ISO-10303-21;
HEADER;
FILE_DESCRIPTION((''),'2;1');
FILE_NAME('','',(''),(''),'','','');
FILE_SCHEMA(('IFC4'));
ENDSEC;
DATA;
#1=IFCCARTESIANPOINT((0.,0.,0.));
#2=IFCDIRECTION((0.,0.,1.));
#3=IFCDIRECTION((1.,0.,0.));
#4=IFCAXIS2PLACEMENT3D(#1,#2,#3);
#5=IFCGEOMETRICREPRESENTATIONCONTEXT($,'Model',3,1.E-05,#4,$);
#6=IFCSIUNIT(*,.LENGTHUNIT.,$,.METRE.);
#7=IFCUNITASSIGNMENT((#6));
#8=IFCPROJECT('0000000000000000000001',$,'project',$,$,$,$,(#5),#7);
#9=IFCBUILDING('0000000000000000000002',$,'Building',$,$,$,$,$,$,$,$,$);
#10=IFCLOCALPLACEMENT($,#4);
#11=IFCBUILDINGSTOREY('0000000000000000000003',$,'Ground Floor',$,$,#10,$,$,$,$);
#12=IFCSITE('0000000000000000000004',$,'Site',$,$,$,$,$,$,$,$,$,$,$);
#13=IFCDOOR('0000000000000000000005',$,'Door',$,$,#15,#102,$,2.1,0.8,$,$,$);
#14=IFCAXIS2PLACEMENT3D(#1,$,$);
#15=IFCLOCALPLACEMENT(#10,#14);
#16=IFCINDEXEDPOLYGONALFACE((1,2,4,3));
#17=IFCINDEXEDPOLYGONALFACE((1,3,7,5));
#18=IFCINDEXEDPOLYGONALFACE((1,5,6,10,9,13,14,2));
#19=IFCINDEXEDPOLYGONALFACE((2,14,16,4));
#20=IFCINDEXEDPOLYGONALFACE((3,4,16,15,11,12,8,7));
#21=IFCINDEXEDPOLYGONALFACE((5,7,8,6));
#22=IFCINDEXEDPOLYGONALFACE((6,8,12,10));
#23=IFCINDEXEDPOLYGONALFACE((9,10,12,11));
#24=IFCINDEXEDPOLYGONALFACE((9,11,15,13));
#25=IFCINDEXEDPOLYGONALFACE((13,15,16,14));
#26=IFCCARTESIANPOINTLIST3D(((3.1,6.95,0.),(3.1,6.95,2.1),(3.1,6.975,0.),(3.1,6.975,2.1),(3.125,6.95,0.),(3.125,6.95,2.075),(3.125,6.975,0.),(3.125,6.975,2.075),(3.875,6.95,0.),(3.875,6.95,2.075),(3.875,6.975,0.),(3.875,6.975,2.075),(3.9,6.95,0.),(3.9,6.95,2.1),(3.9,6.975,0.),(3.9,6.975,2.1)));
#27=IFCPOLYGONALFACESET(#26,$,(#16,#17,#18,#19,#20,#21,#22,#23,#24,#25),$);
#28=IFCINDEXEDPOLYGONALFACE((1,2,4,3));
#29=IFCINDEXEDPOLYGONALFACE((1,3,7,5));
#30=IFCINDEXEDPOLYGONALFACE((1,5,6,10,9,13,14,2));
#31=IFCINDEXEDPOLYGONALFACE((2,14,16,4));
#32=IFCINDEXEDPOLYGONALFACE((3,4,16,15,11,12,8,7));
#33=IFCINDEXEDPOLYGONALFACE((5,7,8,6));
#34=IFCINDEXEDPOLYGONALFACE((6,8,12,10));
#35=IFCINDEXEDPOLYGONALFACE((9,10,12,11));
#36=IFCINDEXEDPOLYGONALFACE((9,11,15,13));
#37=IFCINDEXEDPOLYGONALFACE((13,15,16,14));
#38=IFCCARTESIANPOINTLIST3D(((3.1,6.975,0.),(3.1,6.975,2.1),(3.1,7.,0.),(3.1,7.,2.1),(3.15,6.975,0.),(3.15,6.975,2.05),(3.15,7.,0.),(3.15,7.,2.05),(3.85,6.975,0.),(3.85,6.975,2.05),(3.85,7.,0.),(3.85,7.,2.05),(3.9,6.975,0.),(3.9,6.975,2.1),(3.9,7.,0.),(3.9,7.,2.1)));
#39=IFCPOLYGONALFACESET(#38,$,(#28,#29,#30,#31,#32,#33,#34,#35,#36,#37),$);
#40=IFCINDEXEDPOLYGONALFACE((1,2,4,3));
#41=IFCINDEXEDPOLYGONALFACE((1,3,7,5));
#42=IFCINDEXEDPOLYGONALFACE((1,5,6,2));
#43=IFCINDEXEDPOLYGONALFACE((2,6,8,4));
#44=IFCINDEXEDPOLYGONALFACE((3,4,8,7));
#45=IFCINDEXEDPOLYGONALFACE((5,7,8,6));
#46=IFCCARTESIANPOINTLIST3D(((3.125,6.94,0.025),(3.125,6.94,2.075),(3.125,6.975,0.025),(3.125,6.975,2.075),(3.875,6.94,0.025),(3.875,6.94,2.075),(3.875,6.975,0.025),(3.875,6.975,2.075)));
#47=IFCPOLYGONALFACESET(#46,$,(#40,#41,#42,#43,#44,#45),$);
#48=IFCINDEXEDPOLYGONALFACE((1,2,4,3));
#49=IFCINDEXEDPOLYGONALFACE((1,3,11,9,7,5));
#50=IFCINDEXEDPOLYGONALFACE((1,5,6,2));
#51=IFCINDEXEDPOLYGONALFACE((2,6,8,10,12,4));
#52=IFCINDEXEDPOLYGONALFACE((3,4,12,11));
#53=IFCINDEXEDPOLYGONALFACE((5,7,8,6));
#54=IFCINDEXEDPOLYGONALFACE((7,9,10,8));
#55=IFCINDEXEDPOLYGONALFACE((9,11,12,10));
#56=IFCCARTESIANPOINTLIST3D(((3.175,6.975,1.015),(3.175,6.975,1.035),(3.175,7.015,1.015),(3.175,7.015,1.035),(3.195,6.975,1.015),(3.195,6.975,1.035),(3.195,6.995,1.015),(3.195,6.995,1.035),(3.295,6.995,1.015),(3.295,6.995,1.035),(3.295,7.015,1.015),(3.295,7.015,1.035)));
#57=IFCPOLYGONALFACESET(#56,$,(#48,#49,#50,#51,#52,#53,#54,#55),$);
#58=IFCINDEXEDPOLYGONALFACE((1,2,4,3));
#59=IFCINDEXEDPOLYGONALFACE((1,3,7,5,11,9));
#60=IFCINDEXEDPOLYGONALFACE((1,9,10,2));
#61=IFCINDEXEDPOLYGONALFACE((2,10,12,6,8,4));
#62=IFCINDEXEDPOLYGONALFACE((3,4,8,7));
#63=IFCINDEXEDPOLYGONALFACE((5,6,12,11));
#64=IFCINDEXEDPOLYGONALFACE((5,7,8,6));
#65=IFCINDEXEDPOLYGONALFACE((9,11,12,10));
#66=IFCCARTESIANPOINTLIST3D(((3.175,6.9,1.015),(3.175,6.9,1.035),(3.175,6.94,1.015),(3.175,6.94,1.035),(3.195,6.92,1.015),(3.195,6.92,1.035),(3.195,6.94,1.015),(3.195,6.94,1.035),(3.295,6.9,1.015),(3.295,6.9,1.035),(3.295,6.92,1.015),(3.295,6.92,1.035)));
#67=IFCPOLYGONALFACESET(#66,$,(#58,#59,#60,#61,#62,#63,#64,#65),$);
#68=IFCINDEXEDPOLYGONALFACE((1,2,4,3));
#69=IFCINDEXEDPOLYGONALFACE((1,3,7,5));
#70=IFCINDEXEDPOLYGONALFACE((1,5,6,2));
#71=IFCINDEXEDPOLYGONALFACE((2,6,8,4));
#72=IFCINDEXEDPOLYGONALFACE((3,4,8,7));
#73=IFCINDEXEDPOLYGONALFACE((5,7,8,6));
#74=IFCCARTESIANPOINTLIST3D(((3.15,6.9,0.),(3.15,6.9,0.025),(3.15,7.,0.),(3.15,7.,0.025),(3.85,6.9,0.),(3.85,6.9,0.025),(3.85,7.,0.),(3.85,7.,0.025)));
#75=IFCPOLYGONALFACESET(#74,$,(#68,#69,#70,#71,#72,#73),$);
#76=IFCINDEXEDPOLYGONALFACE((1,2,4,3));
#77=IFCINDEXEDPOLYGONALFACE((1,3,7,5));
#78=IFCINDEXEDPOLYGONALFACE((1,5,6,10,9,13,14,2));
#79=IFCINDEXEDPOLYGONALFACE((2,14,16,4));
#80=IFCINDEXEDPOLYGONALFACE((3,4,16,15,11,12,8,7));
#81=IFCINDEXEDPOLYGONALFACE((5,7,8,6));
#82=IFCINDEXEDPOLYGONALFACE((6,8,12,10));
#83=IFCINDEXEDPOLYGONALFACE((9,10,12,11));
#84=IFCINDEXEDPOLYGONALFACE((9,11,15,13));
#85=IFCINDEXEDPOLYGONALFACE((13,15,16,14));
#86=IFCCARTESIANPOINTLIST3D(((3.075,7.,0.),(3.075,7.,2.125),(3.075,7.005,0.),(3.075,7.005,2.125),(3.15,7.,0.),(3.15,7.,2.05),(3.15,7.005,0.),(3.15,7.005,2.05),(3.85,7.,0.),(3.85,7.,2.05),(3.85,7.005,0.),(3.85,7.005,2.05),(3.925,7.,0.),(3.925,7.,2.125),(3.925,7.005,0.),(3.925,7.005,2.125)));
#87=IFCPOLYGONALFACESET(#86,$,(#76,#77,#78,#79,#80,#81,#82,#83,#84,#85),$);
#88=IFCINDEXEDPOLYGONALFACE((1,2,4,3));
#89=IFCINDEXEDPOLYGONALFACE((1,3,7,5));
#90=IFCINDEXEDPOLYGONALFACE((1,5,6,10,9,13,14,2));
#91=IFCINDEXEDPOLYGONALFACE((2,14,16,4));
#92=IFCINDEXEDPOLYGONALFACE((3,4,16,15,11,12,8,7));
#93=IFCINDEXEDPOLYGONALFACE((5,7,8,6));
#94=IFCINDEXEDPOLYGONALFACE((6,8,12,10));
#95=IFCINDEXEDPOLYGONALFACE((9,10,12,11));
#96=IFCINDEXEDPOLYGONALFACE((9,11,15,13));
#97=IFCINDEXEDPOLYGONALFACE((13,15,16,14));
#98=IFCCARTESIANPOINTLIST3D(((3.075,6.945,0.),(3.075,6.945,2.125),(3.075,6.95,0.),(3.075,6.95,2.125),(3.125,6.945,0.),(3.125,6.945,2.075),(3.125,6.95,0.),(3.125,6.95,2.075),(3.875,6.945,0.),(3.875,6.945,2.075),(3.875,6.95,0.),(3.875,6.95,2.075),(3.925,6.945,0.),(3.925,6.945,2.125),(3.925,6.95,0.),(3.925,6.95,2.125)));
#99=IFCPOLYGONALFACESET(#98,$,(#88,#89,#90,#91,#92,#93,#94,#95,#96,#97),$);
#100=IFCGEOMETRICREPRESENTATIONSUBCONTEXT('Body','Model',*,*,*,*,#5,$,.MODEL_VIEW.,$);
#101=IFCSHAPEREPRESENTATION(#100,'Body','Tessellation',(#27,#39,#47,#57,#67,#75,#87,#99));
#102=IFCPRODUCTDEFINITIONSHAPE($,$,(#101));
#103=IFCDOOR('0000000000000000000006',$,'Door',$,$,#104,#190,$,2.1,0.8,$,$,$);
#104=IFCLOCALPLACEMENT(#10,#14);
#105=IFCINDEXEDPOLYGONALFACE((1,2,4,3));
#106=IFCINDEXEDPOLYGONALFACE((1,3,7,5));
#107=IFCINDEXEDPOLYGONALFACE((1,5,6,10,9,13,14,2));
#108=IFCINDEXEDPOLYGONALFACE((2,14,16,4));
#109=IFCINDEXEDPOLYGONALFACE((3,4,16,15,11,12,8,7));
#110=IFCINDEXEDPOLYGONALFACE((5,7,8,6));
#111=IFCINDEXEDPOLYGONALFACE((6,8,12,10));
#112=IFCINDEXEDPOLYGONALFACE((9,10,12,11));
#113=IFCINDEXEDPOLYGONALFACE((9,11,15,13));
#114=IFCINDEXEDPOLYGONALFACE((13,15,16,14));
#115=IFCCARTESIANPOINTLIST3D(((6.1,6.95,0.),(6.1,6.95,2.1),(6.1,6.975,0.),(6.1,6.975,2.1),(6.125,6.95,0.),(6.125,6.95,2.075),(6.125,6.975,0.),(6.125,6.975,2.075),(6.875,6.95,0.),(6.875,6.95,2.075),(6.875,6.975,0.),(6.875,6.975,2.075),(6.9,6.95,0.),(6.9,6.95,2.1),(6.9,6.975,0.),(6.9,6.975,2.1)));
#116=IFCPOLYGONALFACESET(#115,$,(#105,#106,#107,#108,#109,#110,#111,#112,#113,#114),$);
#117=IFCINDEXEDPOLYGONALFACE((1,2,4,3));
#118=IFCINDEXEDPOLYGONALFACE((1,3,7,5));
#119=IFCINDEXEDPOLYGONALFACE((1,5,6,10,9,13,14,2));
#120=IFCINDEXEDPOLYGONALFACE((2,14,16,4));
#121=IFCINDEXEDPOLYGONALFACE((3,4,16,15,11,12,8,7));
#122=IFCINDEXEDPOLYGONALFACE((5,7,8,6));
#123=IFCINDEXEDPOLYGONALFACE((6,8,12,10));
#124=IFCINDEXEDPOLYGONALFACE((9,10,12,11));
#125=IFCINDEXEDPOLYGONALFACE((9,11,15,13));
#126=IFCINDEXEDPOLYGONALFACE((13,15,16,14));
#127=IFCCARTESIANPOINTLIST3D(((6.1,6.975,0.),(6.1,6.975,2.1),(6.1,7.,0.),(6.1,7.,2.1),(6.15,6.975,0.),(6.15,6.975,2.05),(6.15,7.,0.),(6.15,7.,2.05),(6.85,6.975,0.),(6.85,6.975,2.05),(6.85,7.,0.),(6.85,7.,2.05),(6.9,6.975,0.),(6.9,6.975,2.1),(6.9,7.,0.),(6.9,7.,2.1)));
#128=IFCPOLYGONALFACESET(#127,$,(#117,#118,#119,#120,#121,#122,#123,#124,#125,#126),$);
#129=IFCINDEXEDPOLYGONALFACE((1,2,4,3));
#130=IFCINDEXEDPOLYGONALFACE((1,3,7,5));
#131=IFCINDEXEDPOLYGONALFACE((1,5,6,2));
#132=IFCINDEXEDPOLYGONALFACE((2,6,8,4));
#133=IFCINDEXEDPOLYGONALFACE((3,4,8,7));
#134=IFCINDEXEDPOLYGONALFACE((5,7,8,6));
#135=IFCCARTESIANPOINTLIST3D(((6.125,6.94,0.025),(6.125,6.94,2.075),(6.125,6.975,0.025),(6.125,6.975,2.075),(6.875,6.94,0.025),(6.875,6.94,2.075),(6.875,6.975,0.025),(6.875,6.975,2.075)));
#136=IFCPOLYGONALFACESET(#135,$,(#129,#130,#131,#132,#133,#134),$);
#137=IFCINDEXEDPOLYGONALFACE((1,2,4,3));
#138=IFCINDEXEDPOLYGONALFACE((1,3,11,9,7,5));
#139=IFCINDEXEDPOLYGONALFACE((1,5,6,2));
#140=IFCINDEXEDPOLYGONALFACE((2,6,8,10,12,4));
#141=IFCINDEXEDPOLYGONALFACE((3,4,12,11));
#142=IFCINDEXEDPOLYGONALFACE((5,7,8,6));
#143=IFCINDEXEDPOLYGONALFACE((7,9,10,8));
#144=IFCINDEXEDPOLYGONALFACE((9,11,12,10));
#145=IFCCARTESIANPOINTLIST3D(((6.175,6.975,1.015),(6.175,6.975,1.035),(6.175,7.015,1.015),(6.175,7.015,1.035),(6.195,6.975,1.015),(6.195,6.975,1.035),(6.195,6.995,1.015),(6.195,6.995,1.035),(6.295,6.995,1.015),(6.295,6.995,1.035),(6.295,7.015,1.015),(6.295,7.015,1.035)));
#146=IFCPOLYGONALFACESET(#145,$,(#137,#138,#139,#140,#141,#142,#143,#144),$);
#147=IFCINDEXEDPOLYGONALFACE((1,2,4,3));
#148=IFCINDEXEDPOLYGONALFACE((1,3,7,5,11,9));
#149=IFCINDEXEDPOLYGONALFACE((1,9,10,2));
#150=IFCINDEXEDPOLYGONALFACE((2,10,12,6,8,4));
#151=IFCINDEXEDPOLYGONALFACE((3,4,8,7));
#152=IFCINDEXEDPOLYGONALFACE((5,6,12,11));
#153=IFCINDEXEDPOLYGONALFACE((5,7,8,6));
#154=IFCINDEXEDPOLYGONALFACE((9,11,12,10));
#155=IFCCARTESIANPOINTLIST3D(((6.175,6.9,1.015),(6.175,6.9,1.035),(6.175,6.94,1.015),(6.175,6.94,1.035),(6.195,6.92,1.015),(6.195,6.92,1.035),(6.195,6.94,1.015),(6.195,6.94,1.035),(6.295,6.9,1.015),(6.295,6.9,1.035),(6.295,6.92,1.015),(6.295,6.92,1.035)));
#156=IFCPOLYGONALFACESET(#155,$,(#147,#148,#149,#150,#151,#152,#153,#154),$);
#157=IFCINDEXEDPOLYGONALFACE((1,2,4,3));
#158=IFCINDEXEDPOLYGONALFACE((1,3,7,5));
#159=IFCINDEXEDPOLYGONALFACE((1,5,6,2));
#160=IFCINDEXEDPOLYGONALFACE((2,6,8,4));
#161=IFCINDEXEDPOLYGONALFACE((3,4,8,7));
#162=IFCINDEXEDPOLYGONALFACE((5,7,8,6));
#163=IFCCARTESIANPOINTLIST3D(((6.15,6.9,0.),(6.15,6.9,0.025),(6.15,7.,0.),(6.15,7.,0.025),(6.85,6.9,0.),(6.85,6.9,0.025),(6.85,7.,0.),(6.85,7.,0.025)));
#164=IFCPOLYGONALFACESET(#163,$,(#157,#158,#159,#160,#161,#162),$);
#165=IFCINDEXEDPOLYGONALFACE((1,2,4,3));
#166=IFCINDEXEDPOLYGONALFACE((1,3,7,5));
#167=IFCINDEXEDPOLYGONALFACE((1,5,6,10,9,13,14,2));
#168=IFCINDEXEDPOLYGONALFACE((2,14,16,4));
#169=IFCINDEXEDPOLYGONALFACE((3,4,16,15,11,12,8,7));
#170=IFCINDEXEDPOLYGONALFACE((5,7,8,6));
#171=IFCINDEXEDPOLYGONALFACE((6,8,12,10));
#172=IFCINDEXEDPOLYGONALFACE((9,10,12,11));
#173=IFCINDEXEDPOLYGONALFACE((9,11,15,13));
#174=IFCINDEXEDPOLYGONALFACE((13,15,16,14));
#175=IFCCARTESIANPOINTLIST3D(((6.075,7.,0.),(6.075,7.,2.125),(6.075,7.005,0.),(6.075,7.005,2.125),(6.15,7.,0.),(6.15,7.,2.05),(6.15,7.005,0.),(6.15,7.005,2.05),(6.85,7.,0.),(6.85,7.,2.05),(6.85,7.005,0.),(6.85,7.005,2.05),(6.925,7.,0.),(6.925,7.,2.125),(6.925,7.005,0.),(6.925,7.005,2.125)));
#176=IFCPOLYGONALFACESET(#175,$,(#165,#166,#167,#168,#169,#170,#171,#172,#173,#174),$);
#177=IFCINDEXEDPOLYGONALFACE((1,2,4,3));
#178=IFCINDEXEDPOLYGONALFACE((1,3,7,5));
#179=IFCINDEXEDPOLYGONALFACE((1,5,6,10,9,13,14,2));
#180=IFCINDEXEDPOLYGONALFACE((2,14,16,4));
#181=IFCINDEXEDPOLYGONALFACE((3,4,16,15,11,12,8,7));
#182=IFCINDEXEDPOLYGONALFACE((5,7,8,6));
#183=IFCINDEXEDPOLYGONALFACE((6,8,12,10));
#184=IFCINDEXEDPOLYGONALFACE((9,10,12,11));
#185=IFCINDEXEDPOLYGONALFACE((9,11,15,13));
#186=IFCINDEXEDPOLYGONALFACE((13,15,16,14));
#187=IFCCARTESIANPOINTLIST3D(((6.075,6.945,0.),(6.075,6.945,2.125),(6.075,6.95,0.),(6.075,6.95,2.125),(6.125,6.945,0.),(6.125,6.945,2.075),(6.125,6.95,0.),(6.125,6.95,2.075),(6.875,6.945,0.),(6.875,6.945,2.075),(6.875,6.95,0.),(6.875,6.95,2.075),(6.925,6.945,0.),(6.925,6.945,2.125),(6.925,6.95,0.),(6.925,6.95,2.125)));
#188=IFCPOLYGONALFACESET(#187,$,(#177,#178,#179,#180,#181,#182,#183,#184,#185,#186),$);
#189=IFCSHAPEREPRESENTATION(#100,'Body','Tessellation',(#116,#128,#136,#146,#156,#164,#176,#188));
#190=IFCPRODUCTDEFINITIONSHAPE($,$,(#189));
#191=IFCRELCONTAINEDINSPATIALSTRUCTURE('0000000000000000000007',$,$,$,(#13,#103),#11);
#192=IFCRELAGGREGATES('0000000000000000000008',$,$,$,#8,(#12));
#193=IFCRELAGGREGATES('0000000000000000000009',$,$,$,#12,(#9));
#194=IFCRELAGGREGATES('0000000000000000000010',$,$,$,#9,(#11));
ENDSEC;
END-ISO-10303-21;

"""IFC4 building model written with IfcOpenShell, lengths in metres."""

from ifc_helpers import new_model, si_unit, frame, origin_with_axes, place, context, subcontext, project, spatial, line, indexed_curve, outline, extrude, element, save


model = new_model("IFC4")

# Units and contexts
model_context = context("Model", 3, precision=1e-05, world=origin_with_axes())
body_context = subcontext(model_context, "Body", "Model", "MODEL_VIEW")
ifc_project = project(units=[si_unit("LENGTHUNIT", "METRE")], contexts=[model_context])

# Site, building, storey
site = spatial("IfcSite", under=ifc_project, Name="Site")
building = spatial("IfcBuilding", under=site, Name="Building")
storey_placement = place(None, origin_with_axes())
storey = spatial("IfcBuildingStorey", under=building, at=storey_placement, Name="Ground Floor")

# Doors
door_1_placement = place(storey_placement, frame((3.9, 7.0, 0.0), z_axis=(0.0, 0.0, 1.0), x_axis=(-1.0, 0.0, 0.0)))
element("IfcDoor", 1, at=door_1_placement, inside=storey, Name="Door", OverallHeight=2.1, OverallWidth=0.8, context=body_context, shape_type="SweptSolid", body=[
    extrude(outline(indexed_curve([(0.0, 0.0), (0.0, 2.1), (0.8, 2.1), (0.8, 0.0), (0.775, 0.0), (0.775, 2.075), (0.025, 2.075), (0.025, 0.0)], segments=[line(1, 2, 3, 4, 5, 6, 7, 8, 1)])), frame((0.0, 0.025, 0.0), z_axis=(0.0, -1.0, 0.0), x_axis=(1.0, 0.0, 0.0)), (0.0, 0.0, -1.0), 0.025),
    extrude(outline(indexed_curve([(0.0, 0.0), (0.0, 2.1), (0.8, 2.1), (0.8, 0.0), (0.75, 0.0), (0.75, 2.05), (0.05, 2.05), (0.05, 0.0)], segments=[line(1, 2, 3, 4, 5, 6, 7, 8, 1)])), frame((0.0, 0.0, 0.0), z_axis=(0.0, -1.0, 0.0), x_axis=(1.0, 0.0, 0.0)), (0.0, 0.0, -1.0), 0.025),
    extrude(outline(indexed_curve([(0.0, 0.0), (0.75, 0.0), (0.75, 0.035), (0.0, 0.035)], segments=[line(1, 2, 3, 4, 1)])), frame((0.025, 0.025, 0.025), z_axis=(0.0, 0.0, 1.0), x_axis=(1.0, 0.0, 0.0)), (0.0, 0.0, 1.0), 2.05),
    extrude(outline(indexed_curve([(0.0, 0.0), (0.0, -0.04), (-0.12, -0.04), (-0.12, -0.02), (-0.02, -0.02), (-0.02, 0.0)], segments=[line(1, 2, 3, 4, 5, 6, 1)])), frame((0.725, 0.025, 1.015), z_axis=(0.0, 0.0, 1.0), x_axis=(1.0, 0.0, 0.0)), (0.0, 0.0, 1.0), 0.02),
    extrude(outline(indexed_curve([(0.0, 0.0), (0.0, 0.04), (-0.12, 0.04), (-0.12, 0.02), (-0.02, 0.02), (-0.02, 0.0)], segments=[line(1, 2, 3, 4, 5, 6, 1)])), frame((0.725, 0.06, 1.015), z_axis=(0.0, 0.0, 1.0), x_axis=(1.0, 0.0, 0.0)), (0.0, 0.0, 1.0), 0.02),
    extrude(outline(indexed_curve([(0.0, 0.0), (0.7, 0.0), (0.7, 0.1), (0.0, 0.1)], segments=[line(1, 2, 3, 4, 1)])), frame((0.05, 0.0, 0.0), z_axis=(0.0, 0.0, 1.0), x_axis=(1.0, 0.0, 0.0)), (0.0, 0.0, 1.0), 0.025),
    extrude(outline(indexed_curve([(0.0, 0.0), (0.0, 2.125), (0.85, 2.125), (0.85, 0.0), (0.775, 0.0), (0.775, 2.05), (0.075, 2.05), (0.075, 0.0)], segments=[line(1, 2, 3, 4, 5, 6, 7, 8, 1)])), frame((-0.025, -0.005, 0.0), z_axis=(0.0, -1.0, 0.0), x_axis=(1.0, 0.0, 0.0)), (0.0, 0.0, -1.0), 0.005),
    extrude(outline(indexed_curve([(0.0, 0.0), (0.0, 2.125), (0.85, 2.125), (0.85, 0.0), (0.8, 0.0), (0.8, 2.075), (0.05, 2.075), (0.05, 0.0)], segments=[line(1, 2, 3, 4, 5, 6, 7, 8, 1)])), frame((-0.025, 0.05, 0.0), z_axis=(0.0, -1.0, 0.0), x_axis=(1.0, 0.0, 0.0)), (0.0, 0.0, -1.0), 0.005),
])
door_2_placement = place(storey_placement, frame((6.9, 7.0, 0.0), z_axis=(0.0, 0.0, 1.0), x_axis=(-1.0, 0.0, 0.0)))
element("IfcDoor", 2, at=door_2_placement, inside=storey, Name="Door", OverallHeight=2.1, OverallWidth=0.8, context=body_context, shape_type="SweptSolid", body=[
    extrude(outline(indexed_curve([(0.0, 0.0), (0.0, 2.1), (0.8, 2.1), (0.8, 0.0), (0.775, 0.0), (0.775, 2.075), (0.025, 2.075), (0.025, 0.0)], segments=[line(1, 2, 3, 4, 5, 6, 7, 8, 1)])), frame((0.0, 0.025, 0.0), z_axis=(0.0, -1.0, 0.0), x_axis=(1.0, 0.0, 0.0)), (0.0, 0.0, -1.0), 0.025),
    extrude(outline(indexed_curve([(0.0, 0.0), (0.0, 2.1), (0.8, 2.1), (0.8, 0.0), (0.75, 0.0), (0.75, 2.05), (0.05, 2.05), (0.05, 0.0)], segments=[line(1, 2, 3, 4, 5, 6, 7, 8, 1)])), frame((0.0, 0.0, 0.0), z_axis=(0.0, -1.0, 0.0), x_axis=(1.0, 0.0, 0.0)), (0.0, 0.0, -1.0), 0.025),
    extrude(outline(indexed_curve([(0.0, 0.0), (0.75, 0.0), (0.75, 0.035), (0.0, 0.035)], segments=[line(1, 2, 3, 4, 1)])), frame((0.025, 0.025, 0.025), z_axis=(0.0, 0.0, 1.0), x_axis=(1.0, 0.0, 0.0)), (0.0, 0.0, 1.0), 2.05),
    extrude(outline(indexed_curve([(0.0, 0.0), (0.0, -0.04), (-0.12, -0.04), (-0.12, -0.02), (-0.02, -0.02), (-0.02, 0.0)], segments=[line(1, 2, 3, 4, 5, 6, 1)])), frame((0.725, 0.025, 1.015), z_axis=(0.0, 0.0, 1.0), x_axis=(1.0, 0.0, 0.0)), (0.0, 0.0, 1.0), 0.02),
    extrude(outline(indexed_curve([(0.0, 0.0), (0.0, 0.04), (-0.12, 0.04), (-0.12, 0.02), (-0.02, 0.02), (-0.02, 0.0)], segments=[line(1, 2, 3, 4, 5, 6, 1)])), frame((0.725, 0.06, 1.015), z_axis=(0.0, 0.0, 1.0), x_axis=(1.0, 0.0, 0.0)), (0.0, 0.0, 1.0), 0.02),
    extrude(outline(indexed_curve([(0.0, 0.0), (0.7, 0.0), (0.7, 0.1), (0.0, 0.1)], segments=[line(1, 2, 3, 4, 1)])), frame((0.05, 0.0, 0.0), z_axis=(0.0, 0.0, 1.0), x_axis=(1.0, 0.0, 0.0)), (0.0, 0.0, 1.0), 0.025),
    extrude(outline(indexed_curve([(0.0, 0.0), (0.0, 2.125), (0.85, 2.125), (0.85, 0.0), (0.775, 0.0), (0.775, 2.05), (0.075, 2.05), (0.075, 0.0)], segments=[line(1, 2, 3, 4, 5, 6, 7, 8, 1)])), frame((-0.025, -0.005, 0.0), z_axis=(0.0, -1.0, 0.0), x_axis=(1.0, 0.0, 0.0)), (0.0, 0.0, -1.0), 0.005),
    extrude(outline(indexed_curve([(0.0, 0.0), (0.0, 2.125), (0.85, 2.125), (0.85, 0.0), (0.8, 0.0), (0.8, 2.075), (0.05, 2.075), (0.05, 0.0)], segments=[line(1, 2, 3, 4, 5, 6, 7, 8, 1)])), frame((-0.025, 0.05, 0.0), z_axis=(0.0, -1.0, 0.0), x_axis=(1.0, 0.0, 0.0)), (0.0, 0.0, -1.0), 0.005),
])

save(model, "model.ifc")
